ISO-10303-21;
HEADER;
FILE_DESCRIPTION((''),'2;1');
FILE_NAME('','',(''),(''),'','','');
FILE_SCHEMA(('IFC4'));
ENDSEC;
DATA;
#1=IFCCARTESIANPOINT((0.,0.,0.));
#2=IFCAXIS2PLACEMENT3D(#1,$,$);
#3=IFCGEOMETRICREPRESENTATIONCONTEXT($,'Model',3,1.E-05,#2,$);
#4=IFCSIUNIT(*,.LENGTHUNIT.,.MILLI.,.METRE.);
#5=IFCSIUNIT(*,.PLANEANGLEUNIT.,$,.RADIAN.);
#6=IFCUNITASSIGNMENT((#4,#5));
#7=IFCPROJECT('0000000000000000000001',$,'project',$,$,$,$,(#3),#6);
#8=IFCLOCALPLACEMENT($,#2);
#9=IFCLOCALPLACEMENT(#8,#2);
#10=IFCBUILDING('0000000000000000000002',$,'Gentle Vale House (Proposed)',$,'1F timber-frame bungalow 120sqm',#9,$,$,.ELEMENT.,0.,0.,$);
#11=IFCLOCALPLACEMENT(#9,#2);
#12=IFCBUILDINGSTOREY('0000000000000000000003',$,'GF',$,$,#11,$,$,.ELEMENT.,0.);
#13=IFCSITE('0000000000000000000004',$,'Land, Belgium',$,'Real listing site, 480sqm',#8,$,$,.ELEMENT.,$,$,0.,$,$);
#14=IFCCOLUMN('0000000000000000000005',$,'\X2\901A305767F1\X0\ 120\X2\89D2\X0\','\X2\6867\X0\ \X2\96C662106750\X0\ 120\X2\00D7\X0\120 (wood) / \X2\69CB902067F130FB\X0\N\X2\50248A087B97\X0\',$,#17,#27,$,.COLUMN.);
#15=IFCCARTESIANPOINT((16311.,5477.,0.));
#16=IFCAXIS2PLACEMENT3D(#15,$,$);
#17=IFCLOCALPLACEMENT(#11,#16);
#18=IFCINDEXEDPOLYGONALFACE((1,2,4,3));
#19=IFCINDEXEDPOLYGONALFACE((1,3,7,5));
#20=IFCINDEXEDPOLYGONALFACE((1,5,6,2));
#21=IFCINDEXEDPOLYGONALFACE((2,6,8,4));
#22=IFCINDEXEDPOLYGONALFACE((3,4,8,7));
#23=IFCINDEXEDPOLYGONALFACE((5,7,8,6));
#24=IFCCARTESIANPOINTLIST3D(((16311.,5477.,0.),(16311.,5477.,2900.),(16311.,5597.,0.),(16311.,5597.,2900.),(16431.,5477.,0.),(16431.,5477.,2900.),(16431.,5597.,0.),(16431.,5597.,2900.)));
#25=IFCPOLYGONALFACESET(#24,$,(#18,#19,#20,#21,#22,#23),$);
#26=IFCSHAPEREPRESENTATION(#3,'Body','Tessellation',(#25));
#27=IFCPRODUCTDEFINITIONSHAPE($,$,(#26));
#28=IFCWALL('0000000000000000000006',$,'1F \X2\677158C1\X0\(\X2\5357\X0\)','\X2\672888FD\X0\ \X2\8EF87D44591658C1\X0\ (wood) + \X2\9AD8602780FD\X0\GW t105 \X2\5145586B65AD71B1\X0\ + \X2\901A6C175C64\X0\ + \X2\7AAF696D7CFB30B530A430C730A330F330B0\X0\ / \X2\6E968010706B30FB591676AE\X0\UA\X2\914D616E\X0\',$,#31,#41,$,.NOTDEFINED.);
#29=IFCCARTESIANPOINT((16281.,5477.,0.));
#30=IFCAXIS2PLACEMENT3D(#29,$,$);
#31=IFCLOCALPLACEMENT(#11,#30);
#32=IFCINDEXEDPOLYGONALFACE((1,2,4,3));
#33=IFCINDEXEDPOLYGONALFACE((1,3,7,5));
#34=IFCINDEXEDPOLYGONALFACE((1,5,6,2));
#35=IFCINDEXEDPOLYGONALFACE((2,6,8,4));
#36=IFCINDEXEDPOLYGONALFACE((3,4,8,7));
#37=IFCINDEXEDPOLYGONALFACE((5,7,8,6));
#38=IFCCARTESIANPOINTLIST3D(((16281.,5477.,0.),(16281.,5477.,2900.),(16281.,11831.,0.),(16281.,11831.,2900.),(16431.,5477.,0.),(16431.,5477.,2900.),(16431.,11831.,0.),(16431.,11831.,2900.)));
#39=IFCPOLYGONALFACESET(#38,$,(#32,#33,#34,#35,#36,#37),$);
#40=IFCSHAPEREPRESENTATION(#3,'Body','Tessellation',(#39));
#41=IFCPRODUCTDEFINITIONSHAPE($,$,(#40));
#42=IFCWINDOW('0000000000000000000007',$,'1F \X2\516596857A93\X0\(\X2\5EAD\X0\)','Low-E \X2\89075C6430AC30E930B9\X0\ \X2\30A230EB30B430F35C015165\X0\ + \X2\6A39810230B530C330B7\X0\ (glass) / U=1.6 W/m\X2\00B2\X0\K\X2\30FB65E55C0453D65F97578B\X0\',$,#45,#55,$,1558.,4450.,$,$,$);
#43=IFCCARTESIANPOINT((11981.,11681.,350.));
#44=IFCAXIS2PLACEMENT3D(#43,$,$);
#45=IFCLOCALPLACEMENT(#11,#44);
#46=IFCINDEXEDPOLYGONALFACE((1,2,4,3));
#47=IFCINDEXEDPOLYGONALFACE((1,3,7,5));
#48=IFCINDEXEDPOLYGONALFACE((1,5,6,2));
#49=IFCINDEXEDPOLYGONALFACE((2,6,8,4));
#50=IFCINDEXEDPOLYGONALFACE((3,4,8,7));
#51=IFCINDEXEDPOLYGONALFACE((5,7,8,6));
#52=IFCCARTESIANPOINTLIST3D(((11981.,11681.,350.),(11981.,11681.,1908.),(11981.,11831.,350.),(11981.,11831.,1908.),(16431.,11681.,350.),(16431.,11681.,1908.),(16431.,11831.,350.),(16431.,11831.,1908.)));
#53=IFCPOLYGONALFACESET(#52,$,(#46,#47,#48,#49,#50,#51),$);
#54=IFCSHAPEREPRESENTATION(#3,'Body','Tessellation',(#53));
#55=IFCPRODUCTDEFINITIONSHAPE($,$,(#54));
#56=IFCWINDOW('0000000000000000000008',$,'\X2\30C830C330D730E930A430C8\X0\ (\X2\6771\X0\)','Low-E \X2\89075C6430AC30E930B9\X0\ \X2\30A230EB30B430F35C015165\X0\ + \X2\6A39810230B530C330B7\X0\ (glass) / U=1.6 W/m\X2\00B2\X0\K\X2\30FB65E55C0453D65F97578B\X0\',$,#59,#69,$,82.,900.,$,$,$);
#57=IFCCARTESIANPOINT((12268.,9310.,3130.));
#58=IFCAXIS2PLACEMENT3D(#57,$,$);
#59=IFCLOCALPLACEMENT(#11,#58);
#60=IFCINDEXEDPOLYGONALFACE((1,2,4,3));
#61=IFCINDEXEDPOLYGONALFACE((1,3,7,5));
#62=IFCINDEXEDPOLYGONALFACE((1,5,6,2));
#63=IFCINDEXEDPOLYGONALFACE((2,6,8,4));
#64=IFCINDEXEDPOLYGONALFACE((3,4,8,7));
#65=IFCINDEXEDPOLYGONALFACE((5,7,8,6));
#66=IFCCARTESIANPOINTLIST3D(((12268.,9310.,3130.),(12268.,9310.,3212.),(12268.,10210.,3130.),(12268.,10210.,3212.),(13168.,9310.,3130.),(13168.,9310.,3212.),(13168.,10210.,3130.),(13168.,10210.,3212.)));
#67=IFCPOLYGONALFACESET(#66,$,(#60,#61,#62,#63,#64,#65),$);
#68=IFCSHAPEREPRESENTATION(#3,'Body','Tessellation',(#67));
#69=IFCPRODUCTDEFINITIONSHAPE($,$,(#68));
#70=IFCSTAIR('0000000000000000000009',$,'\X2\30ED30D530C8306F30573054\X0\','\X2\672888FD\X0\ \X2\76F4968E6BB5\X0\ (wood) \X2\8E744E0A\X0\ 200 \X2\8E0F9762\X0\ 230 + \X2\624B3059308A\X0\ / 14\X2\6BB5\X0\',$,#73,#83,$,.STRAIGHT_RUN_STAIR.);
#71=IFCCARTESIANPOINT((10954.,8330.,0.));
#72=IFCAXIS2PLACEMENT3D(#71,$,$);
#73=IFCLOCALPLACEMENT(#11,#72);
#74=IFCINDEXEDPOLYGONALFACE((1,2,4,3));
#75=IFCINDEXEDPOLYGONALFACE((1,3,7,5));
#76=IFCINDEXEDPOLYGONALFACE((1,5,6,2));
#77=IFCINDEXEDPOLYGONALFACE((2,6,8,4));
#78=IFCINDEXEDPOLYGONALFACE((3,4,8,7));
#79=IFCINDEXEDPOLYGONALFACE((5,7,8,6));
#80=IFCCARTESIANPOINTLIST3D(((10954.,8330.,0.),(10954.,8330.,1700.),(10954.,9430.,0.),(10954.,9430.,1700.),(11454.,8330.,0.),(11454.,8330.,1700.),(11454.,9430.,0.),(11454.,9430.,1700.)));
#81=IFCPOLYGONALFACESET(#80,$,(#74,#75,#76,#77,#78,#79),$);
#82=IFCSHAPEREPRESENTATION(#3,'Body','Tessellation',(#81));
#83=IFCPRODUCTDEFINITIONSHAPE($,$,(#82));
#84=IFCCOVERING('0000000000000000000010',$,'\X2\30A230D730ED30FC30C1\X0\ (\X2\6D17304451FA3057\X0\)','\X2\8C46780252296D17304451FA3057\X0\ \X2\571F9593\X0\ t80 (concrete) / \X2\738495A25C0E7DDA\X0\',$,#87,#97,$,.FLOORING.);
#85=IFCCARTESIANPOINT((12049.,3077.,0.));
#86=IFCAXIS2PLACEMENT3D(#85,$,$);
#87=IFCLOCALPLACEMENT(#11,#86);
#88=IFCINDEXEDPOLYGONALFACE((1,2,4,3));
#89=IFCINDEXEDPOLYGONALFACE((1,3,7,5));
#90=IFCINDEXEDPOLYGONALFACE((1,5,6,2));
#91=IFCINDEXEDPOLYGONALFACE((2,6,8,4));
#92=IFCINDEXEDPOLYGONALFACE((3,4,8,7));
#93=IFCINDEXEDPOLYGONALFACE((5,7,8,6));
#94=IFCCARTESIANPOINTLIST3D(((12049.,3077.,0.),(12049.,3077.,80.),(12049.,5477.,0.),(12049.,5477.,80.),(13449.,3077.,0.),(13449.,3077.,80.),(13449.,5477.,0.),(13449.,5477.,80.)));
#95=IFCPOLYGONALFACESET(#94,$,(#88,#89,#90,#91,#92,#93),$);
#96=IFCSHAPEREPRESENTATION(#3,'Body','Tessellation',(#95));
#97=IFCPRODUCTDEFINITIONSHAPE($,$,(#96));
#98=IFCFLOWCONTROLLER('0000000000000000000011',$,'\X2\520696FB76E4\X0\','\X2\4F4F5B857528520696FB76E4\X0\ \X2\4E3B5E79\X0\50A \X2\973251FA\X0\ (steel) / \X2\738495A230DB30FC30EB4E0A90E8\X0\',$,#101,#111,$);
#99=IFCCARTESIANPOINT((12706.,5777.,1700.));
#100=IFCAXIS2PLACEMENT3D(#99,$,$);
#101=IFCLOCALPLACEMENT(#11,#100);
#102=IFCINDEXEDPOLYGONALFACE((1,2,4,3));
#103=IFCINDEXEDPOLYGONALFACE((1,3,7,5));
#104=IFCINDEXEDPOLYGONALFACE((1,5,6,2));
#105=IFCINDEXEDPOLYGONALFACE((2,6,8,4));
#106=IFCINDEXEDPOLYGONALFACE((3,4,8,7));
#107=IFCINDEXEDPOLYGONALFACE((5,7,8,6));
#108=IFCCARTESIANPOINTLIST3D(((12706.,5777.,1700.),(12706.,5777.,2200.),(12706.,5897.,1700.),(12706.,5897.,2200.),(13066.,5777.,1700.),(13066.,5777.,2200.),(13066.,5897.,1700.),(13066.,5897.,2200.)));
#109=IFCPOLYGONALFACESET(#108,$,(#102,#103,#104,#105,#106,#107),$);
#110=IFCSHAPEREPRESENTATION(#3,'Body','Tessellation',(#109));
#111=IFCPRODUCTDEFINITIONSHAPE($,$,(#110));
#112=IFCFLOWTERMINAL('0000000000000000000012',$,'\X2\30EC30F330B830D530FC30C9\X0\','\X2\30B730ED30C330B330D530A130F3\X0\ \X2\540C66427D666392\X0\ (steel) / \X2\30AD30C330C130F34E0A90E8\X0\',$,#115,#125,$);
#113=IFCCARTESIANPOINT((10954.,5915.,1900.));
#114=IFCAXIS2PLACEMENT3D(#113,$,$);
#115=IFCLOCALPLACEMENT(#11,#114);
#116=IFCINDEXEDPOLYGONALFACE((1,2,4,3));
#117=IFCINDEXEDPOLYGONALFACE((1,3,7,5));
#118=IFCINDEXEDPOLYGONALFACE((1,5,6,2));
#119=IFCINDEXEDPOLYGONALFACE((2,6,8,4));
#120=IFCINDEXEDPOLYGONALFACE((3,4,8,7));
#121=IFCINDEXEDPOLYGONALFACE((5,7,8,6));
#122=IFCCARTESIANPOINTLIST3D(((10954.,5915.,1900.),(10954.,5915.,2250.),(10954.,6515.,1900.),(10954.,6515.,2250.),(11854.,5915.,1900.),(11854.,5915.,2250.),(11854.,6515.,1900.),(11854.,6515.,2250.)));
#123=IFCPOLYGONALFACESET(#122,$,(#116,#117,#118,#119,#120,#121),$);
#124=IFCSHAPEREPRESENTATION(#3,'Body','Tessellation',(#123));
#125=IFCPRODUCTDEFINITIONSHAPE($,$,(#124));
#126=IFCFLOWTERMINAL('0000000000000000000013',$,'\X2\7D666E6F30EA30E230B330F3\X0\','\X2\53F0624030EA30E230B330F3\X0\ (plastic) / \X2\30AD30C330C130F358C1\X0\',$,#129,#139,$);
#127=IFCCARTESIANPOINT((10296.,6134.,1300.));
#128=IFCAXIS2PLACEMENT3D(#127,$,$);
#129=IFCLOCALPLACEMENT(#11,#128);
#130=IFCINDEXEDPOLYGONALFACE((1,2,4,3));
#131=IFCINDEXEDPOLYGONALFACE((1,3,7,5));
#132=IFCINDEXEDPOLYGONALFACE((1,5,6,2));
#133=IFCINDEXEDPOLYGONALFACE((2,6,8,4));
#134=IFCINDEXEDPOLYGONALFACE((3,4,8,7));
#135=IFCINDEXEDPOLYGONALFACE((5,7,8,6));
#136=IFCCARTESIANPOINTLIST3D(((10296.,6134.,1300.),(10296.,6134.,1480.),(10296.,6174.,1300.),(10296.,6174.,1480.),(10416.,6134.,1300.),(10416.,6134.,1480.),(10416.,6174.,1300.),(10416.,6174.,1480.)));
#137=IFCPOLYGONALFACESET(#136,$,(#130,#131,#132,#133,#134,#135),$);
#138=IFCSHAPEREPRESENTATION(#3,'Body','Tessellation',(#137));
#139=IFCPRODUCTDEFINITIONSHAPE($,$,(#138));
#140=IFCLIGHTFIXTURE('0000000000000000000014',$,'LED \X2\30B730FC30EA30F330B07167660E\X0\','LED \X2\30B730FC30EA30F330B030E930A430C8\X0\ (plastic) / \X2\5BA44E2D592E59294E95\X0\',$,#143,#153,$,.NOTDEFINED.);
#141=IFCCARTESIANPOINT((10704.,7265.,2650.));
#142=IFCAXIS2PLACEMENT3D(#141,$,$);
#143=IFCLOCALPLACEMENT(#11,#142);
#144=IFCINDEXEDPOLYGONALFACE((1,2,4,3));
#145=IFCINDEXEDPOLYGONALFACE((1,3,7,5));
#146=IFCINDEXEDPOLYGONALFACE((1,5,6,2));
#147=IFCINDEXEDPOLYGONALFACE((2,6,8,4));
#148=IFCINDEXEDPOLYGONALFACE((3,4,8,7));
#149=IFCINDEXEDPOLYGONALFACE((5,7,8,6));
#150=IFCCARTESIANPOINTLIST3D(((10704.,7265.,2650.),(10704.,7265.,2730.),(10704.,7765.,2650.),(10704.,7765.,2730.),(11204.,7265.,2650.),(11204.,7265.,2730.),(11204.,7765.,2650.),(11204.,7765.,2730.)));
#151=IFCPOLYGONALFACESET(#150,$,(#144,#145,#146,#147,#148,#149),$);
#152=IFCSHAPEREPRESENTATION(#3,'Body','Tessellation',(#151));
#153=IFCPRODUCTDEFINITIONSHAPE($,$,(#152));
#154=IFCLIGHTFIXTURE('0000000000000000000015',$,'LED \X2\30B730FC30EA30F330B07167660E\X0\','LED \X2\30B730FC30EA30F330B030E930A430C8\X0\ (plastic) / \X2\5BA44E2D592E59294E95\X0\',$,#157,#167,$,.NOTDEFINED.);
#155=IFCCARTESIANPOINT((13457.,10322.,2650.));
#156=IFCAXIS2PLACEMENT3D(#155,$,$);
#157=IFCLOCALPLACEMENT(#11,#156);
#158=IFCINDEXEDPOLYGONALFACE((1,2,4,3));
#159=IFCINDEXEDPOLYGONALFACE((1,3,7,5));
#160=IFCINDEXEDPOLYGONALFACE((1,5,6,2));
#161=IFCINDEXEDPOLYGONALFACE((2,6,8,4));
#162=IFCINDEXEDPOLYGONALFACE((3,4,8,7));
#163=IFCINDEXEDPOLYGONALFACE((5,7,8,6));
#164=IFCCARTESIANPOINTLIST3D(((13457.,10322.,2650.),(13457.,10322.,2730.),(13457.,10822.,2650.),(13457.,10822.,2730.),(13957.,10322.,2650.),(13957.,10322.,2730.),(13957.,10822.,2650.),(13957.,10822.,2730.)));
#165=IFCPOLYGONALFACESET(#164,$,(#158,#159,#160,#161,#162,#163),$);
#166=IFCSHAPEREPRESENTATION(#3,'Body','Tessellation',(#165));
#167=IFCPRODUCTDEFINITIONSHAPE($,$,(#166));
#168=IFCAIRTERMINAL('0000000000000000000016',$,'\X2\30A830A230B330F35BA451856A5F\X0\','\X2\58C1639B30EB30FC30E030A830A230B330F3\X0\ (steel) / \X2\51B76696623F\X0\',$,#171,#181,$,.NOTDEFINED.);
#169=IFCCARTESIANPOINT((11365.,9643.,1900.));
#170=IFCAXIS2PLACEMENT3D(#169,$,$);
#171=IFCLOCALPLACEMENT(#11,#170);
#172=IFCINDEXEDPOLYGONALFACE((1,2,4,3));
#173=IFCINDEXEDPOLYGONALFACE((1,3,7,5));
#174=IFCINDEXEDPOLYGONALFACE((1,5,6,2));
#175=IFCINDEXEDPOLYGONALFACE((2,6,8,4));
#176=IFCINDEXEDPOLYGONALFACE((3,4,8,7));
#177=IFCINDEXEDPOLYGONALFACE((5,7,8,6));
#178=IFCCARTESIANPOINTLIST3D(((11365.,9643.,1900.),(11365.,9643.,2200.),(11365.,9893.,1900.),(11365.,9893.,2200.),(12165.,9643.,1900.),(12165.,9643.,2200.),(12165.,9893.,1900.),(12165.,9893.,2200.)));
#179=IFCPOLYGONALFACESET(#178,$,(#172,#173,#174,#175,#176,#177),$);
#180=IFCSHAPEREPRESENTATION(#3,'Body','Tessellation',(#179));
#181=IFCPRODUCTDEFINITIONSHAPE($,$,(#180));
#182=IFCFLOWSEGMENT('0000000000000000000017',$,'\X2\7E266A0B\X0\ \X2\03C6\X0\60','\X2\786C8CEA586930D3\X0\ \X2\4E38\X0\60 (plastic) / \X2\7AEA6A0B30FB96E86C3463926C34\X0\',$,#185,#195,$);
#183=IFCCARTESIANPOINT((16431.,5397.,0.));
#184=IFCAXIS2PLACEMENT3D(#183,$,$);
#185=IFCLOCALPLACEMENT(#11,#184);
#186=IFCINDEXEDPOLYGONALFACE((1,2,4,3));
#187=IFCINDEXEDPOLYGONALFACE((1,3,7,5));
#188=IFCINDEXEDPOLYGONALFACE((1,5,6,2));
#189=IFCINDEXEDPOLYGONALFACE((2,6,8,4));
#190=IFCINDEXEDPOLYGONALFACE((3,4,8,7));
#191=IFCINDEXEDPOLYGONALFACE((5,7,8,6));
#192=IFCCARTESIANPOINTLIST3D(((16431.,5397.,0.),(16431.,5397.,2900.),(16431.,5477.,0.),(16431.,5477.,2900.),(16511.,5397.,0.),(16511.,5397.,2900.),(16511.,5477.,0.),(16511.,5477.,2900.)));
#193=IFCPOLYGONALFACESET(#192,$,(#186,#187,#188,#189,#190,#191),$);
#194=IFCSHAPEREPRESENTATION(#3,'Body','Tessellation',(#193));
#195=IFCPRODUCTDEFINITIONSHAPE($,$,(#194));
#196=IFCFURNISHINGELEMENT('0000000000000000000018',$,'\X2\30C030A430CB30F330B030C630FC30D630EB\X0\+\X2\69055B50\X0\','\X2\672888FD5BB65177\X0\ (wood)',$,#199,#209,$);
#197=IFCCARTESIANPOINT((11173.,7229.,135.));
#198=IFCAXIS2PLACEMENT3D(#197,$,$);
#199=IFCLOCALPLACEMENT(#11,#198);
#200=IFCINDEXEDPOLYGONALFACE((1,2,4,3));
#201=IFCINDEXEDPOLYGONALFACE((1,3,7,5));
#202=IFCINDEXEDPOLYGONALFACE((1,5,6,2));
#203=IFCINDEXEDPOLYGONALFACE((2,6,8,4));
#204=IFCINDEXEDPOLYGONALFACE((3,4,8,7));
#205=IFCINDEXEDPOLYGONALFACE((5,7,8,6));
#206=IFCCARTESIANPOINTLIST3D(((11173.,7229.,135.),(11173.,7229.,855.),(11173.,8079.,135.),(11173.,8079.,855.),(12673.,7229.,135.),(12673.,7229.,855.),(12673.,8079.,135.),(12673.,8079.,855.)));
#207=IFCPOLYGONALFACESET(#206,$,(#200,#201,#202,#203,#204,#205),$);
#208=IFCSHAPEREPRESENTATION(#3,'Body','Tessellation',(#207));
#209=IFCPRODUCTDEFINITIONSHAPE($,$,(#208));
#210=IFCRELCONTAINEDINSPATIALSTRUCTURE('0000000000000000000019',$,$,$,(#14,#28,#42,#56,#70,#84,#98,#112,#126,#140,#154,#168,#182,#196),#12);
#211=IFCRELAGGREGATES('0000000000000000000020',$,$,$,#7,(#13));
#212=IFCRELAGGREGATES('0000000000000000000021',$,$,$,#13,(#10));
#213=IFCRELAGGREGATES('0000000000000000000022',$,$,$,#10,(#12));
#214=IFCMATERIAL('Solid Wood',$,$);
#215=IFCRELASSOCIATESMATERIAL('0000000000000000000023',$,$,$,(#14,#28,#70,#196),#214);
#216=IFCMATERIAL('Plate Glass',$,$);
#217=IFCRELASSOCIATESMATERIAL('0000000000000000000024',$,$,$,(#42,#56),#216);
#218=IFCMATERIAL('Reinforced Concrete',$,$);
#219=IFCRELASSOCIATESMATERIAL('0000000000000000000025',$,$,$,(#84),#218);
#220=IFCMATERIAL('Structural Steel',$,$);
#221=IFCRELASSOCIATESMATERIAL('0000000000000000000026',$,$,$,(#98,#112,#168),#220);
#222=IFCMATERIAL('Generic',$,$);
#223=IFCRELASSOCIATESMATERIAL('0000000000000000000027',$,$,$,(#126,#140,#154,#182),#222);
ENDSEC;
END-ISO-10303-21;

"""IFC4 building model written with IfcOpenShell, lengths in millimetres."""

from ifc_helpers import new_model, si_unit, frame, frame_2d, origin, place, context, project, spatial, rectangle, extrude, material, element, fill, save


model = new_model("IFC4")

# Units and contexts
model_context = context("Model", 3, precision=1e-05, world=origin())
ifc_project = project(units=[si_unit("LENGTHUNIT", "METRE", prefix="MILLI"), si_unit("PLANEANGLEUNIT", "RADIAN")], contexts=[model_context])

# Site, building, storey
site_placement = place(None, origin())
site = spatial("IfcSite", under=ifc_project, at=site_placement, Name="Land, Belgium", ObjectType="Real listing site, 480sqm", CompositionType="ELEMENT", RefElevation=0.0)
building_placement = place(site_placement, origin())
building = spatial("IfcBuilding", under=site, at=building_placement, Name="Gentle Vale House (Proposed)", ObjectType="1F timber-frame bungalow 120sqm", CompositionType="ELEMENT", ElevationOfRefHeight=0.0, ElevationOfTerrain=0.0)
storey_placement = place(building_placement, origin())
storey = spatial("IfcBuildingStorey", under=building, at=storey_placement, Name="GF", CompositionType="ELEMENT", Elevation=0.0)

# Column
ifc_material_1 = material(Name="Solid Wood")
column_1_placement = place(storey_placement, frame((16311.0, 5477.0, 0.0)))
element("IfcColumn", 1, at=column_1_placement, inside=storey, material=ifc_material_1, Name="通し柱 120角", Description="桧 集成材 120×120 (wood) / 構造柱・N値計算", PredefinedType="COLUMN", context=model_context, shape_type="SweptSolid", body=[
    extrude(rectangle(XDim=120.0, YDim=120.0, at=frame_2d((60.0, 60.0))), frame((16311.0, 5477.0, 0.0)), (0.0, 0.0, 1.0), 2900.0),
])

# Wall, opening, window
wall_1_placement = place(storey_placement, frame((16281.0, 5477.0, 0.0)))
wall_1 = element("IfcWall", 2, at=wall_1_placement, inside=storey, material=ifc_material_1, Name="1F 東壁(南)", Description="木製 軸組外壁 (wood) + 高性能GW t105 充填断熱 + 通気層 + 窯業系サイディング / 準耐火・外皮UA配慮", PredefinedType="NOTDEFINED", context=model_context, shape_type="SweptSolid", body=[
    extrude(rectangle(XDim=150.0, YDim=6354.0, at=frame_2d((75.0, 3177.0))), frame((16281.0, 5477.0, 0.0)), (0.0, 0.0, 1.0), 2900.0),
])
opening_1_placement = place(storey_placement, frame((11981.0, 11681.0, 350.0)))
opening_1 = element("IfcOpeningElement", 3, at=opening_1_placement, cuts=wall_1, PredefinedType="NOTDEFINED", context=model_context, shape_type="SweptSolid", body=[
    extrude(rectangle(XDim=4450.0, YDim=150.0, at=frame_2d((2225.0, 75.0))), frame((11981.0, 11681.0, 350.0)), (0.0, 0.0, 1.0), 1558.0),
])
ifc_material_2 = material(Name="Plate Glass")
window_1_placement = place(storey_placement, frame((11981.0, 11681.0, 350.0)))
window_1 = element("IfcWindow", 4, at=window_1_placement, inside=storey, material=ifc_material_2, Name="1F 入隅窓(庭)", Description="Low-E 複層ガラス アルゴン封入 + 樹脂サッシ (glass) / U=1.6 W/m²K・日射取得型", OverallHeight=1558.0, OverallWidth=4450.0, context=model_context, shape_type="SweptSolid", body=[
    extrude(rectangle(XDim=4450.0, YDim=150.0, at=frame_2d((2225.0, 75.0))), frame((11981.0, 11681.0, 350.0)), (0.0, 0.0, 1.0), 1558.0),
])
fill(opening_1, window_1)

# Window
window_2_placement = place(storey_placement, frame((12268.0, 9310.0, 3130.0)))
element("IfcWindow", 5, at=window_2_placement, inside=storey, material=ifc_material_2, Name="トップライト (東)", Description="Low-E 複層ガラス アルゴン封入 + 樹脂サッシ (glass) / U=1.6 W/m²K・日射取得型", OverallHeight=82.0, OverallWidth=900.0, context=model_context, shape_type="SweptSolid", body=[
    extrude(rectangle(XDim=900.0, YDim=900.0, at=frame_2d((450.0, 450.0))), frame((12268.0, 9310.0, 3130.0)), (0.0, 0.0, 1.0), 82.0),
])

# Stair
stair_placement = place(storey_placement, frame((10954.0, 8330.0, 0.0)))
element("IfcStair", 6, at=stair_placement, inside=storey, material=ifc_material_1, Name="ロフトはしご", Description="木製 直階段 (wood) 蹴上 200 踏面 230 + 手すり / 14段", PredefinedType="STRAIGHT_RUN_STAIR", context=model_context, shape_type="SweptSolid", body=[
    extrude(rectangle(XDim=500.0, YDim=1100.0, at=frame_2d((250.0, 550.0))), frame((10954.0, 8330.0, 0.0)), (0.0, 0.0, 1.0), 1700.0),
])

# Covering
ifc_material_3 = material(Name="Reinforced Concrete")
covering_placement = place(storey_placement, frame((12049.0, 3077.0, 0.0)))
element("IfcCovering", 7, at=covering_placement, inside=storey, material=ifc_material_3, Name="アプローチ (洗い出し)", Description="豆砂利洗い出し 土間 t80 (concrete) / 玄関導線", PredefinedType="FLOORING", context=model_context, shape_type="SweptSolid", body=[
    extrude(rectangle(XDim=1400.0, YDim=2400.0, at=frame_2d((700.0, 1200.0))), frame((12049.0, 3077.0, 0.0)), (0.0, 0.0, 1.0), 80.0),
])

# Flow controller
ifc_material_4 = material(Name="Structural Steel")
flow_controller_placement = place(storey_placement, frame((12706.0, 5777.0, 1700.0)))
element("IfcFlowController", 8, at=flow_controller_placement, inside=storey, material=ifc_material_4, Name="分電盤", Description="住宅用分電盤 主幹50A 露出 (steel) / 玄関ホール上部", context=model_context, shape_type="SweptSolid", body=[
    extrude(rectangle(XDim=360.0, YDim=120.0, at=frame_2d((180.0, 60.0))), frame((12706.0, 5777.0, 1700.0)), (0.0, 0.0, 1.0), 500.0),
])

# Flow terminals
flow_terminal_1_placement = place(storey_placement, frame((10954.0, 5915.0, 1900.0)))
element("IfcFlowTerminal", 9, at=flow_terminal_1_placement, inside=storey, material=ifc_material_4, Name="レンジフード", Description="シロッコファン 同時給排 (steel) / キッチン上部", context=model_context, shape_type="SweptSolid", body=[
    extrude(rectangle(XDim=900.0, YDim=600.0, at=frame_2d((450.0, 300.0))), frame((10954.0, 5915.0, 1900.0)), (0.0, 0.0, 1.0), 350.0),
])
ifc_material_5 = material(Name="Generic")
flow_terminal_2_placement = place(storey_placement, frame((10296.0, 6134.0, 1300.0)))
element("IfcFlowTerminal", 10, at=flow_terminal_2_placement, inside=storey, material=ifc_material_5, Name="給湯リモコン", Description="台所リモコン (plastic) / キッチン壁", context=model_context, shape_type="SweptSolid", body=[
    extrude(rectangle(XDim=120.0, YDim=40.0, at=frame_2d((60.0, 20.0))), frame((10296.0, 6134.0, 1300.0)), (0.0, 0.0, 1.0), 180.0),
])

# Light fixtures
light_fixture_1_placement = place(storey_placement, frame((10704.0, 7265.0, 2650.0)))
element("IfcLightFixture", 11, at=light_fixture_1_placement, inside=storey, material=ifc_material_5, Name="LED シーリング照明", Description="LED シーリングライト (plastic) / 室中央天井", PredefinedType="NOTDEFINED", context=model_context, shape_type="SweptSolid", body=[
    extrude(rectangle(XDim=500.0, YDim=500.0, at=frame_2d((250.0, 250.0))), frame((10704.0, 7265.0, 2650.0)), (0.0, 0.0, 1.0), 80.0),
])
light_fixture_2_placement = place(storey_placement, frame((13457.0, 10322.0, 2650.0)))
element("IfcLightFixture", 12, at=light_fixture_2_placement, inside=storey, material=ifc_material_5, Name="LED シーリング照明", Description="LED シーリングライト (plastic) / 室中央天井", PredefinedType="NOTDEFINED", context=model_context, shape_type="SweptSolid", body=[
    extrude(rectangle(XDim=500.0, YDim=500.0, at=frame_2d((250.0, 250.0))), frame((13457.0, 10322.0, 2650.0)), (0.0, 0.0, 1.0), 80.0),
])

# Air terminal
air_terminal_placement = place(storey_placement, frame((11365.0, 9643.0, 1900.0)))
element("IfcAirTerminal", 13, at=air_terminal_placement, inside=storey, material=ifc_material_4, Name="エアコン室内機", Description="壁掛ルームエアコン (steel) / 冷暖房", PredefinedType="NOTDEFINED", context=model_context, shape_type="SweptSolid", body=[
    extrude(rectangle(XDim=800.0, YDim=250.0, at=frame_2d((400.0, 125.0))), frame((11365.0, 9643.0, 1900.0)), (0.0, 0.0, 1.0), 300.0),
])

# Flow segment
flow_segment_placement = place(storey_placement, frame((16431.0, 5397.0, 0.0)))
element("IfcFlowSegment", 14, at=flow_segment_placement, inside=storey, material=ifc_material_5, Name="縦樋 φ60", Description="硬質塩ビ 丸60 (plastic) / 竪樋・雨水排水", context=model_context, shape_type="SweptSolid", body=[
    extrude(rectangle(XDim=80.0, YDim=80.0, at=frame_2d((40.0, 40.0))), frame((16431.0, 5397.0, 0.0)), (0.0, 0.0, 1.0), 2900.0),
])

# Furnishing element
furnishing_1_placement = place(storey_placement, frame((11173.0, 7229.0, 135.0)))
element("IfcFurnishingElement", 15, at=furnishing_1_placement, inside=storey, material=ifc_material_1, Name="ダイニングテーブル+椅子", Description="木製家具 (wood)", context=model_context, shape_type="SweptSolid", body=[
    extrude(rectangle(XDim=1500.0, YDim=850.0, at=frame_2d((750.0, 425.0))), frame((11173.0, 7229.0, 135.0)), (0.0, 0.0, 1.0), 720.0),
])

save(model, "model.ifc")
